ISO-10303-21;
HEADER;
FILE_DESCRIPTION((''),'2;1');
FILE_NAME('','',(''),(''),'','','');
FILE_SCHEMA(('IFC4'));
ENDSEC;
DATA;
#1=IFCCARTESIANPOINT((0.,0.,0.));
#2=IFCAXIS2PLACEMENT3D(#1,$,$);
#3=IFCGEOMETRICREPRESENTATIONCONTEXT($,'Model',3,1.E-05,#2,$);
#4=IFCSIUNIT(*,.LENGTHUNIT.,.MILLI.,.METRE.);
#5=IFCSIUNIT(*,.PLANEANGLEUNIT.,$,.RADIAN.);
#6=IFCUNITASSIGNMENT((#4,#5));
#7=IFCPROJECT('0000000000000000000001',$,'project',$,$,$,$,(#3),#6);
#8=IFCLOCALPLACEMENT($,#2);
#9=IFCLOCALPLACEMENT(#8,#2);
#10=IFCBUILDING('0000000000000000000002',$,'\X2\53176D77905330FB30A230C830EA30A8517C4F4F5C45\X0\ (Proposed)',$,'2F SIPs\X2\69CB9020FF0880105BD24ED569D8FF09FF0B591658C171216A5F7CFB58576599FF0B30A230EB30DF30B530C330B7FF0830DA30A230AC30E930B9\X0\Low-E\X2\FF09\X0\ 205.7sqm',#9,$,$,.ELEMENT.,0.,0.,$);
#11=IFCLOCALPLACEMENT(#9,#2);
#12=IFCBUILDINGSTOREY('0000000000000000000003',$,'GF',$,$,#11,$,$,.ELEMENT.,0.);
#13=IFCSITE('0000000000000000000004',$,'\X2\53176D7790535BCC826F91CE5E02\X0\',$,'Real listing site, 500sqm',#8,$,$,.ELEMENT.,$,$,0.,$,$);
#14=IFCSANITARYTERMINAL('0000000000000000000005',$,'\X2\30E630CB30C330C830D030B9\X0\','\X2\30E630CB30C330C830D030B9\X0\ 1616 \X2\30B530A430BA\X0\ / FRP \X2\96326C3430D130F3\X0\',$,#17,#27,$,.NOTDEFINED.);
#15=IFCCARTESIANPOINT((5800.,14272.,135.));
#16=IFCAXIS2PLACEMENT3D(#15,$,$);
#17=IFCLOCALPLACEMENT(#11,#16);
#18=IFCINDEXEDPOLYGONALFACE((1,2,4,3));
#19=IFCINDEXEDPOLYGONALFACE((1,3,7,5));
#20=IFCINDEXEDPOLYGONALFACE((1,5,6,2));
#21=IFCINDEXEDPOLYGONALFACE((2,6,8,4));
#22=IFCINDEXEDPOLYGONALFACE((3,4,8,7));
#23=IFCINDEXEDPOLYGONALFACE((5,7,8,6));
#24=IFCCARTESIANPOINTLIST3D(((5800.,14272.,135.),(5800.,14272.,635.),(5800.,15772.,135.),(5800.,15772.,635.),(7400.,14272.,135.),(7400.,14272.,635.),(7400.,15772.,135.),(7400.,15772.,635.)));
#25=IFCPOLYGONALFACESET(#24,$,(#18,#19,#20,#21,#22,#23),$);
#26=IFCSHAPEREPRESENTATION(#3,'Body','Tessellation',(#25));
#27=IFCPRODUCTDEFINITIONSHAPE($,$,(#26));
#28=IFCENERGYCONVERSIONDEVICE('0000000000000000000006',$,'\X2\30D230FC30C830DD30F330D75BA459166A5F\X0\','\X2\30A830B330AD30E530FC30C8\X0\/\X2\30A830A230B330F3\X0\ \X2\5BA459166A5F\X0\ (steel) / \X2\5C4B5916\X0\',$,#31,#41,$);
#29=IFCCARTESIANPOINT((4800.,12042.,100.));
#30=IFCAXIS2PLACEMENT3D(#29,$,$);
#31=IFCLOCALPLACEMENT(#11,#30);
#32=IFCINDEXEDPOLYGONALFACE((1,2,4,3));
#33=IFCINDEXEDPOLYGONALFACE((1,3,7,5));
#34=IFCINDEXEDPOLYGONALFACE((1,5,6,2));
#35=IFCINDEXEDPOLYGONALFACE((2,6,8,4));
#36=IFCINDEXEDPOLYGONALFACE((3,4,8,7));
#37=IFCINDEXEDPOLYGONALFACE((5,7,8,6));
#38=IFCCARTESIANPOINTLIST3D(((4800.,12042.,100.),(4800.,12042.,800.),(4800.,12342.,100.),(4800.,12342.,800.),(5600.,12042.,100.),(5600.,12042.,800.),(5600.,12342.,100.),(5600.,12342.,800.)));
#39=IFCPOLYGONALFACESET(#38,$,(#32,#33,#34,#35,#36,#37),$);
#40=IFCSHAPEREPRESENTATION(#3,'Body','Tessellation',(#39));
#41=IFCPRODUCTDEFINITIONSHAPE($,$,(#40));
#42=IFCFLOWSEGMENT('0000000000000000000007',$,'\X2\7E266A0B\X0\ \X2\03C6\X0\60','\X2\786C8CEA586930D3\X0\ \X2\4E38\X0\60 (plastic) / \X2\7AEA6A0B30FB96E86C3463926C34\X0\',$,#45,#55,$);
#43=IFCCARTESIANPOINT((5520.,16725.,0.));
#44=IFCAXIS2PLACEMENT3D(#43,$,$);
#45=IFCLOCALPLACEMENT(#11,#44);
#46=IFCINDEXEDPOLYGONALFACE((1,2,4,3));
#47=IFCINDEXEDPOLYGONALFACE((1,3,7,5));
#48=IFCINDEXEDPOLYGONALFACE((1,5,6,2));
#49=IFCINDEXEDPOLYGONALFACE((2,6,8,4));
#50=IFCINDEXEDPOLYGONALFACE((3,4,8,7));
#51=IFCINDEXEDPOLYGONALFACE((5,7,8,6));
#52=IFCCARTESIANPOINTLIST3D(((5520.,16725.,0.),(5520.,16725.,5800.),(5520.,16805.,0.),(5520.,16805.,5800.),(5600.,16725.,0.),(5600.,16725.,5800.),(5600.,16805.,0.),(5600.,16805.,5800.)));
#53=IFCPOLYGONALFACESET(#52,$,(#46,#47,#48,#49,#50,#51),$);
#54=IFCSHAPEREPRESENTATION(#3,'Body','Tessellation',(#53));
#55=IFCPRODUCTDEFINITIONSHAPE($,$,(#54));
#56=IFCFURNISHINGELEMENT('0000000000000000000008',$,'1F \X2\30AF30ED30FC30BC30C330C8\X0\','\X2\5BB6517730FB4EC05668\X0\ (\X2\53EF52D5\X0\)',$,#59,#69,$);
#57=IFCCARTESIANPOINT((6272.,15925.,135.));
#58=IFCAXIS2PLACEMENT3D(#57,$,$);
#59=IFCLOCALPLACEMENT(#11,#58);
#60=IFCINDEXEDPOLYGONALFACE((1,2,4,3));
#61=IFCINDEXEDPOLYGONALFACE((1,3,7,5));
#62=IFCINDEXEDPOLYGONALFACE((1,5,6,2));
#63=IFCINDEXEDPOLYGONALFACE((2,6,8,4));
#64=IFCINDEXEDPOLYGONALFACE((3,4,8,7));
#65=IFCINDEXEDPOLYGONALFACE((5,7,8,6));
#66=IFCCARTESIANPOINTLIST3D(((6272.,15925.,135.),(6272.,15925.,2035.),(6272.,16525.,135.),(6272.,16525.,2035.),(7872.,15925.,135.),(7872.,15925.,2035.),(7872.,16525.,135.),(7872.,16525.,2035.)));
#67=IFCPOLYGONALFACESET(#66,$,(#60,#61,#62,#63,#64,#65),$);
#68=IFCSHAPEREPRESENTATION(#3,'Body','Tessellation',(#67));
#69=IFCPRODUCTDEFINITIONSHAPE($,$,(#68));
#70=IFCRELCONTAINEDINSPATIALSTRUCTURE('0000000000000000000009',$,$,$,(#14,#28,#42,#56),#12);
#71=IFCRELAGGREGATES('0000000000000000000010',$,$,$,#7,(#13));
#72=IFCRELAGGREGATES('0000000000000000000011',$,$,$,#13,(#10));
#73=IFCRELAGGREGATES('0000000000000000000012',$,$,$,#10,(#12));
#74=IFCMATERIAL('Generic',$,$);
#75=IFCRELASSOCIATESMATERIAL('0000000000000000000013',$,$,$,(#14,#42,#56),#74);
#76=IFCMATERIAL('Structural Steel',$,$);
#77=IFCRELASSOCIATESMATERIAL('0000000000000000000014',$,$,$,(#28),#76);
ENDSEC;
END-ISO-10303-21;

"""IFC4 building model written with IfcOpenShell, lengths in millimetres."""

from ifc_helpers import new_model, si_unit, frame, frame_2d, origin, place, context, project, spatial, rectangle, extrude, material, element, save


model = new_model("IFC4")

# Units and contexts
model_context = context("Model", 3, precision=1e-05, world=origin())
ifc_project = project(units=[si_unit("LENGTHUNIT", "METRE", prefix="MILLI"), si_unit("PLANEANGLEUNIT", "RADIAN")], contexts=[model_context])

# Site, building, storey
site_placement = place(None, origin())
site = spatial("IfcSite", under=ifc_project, at=site_placement, Name="北海道富良野市", ObjectType="Real listing site, 500sqm", CompositionType="ELEMENT", RefElevation=0.0)
building_placement = place(site_placement, origin())
building = spatial("IfcBuilding", under=site, at=building_placement, Name="北海道・アトリエ兼住居 (Proposed)", ObjectType="2F SIPs構造（耐寒仕様）＋外壁無機系塗料＋アルミサッシ（ペアガラスLow-E） 205.7sqm", CompositionType="ELEMENT", ElevationOfRefHeight=0.0, ElevationOfTerrain=0.0)
storey_placement = place(building_placement, origin())
storey = spatial("IfcBuildingStorey", under=building, at=storey_placement, Name="GF", CompositionType="ELEMENT", Elevation=0.0)

# Shared definitions
ifc_material_1 = material(Name="Generic")

# Sanitary terminal
sanitary_terminal_placement = place(storey_placement, frame((5800.0, 14272.0, 135.0)))
element("IfcSanitaryTerminal", 1, at=sanitary_terminal_placement, inside=storey, material=ifc_material_1, Name="ユニットバス", Description="ユニットバス 1616 サイズ / FRP 防水パン", PredefinedType="NOTDEFINED", context=model_context, shape_type="SweptSolid", body=[
    extrude(rectangle(XDim=1600.0, YDim=1500.0, at=frame_2d((800.0, 750.0))), frame((5800.0, 14272.0, 135.0)), (0.0, 0.0, 1.0), 500.0),
])

# Energy conversion device
ifc_material_2 = material(Name="Structural Steel")
energy_conversion_device_placement = place(storey_placement, frame((4800.0, 12042.0, 100.0)))
element("IfcEnergyConversionDevice", 2, at=energy_conversion_device_placement, inside=storey, material=ifc_material_2, Name="ヒートポンプ室外機", Description="エコキュート/エアコン 室外機 (steel) / 屋外", context=model_context, shape_type="SweptSolid", body=[
    extrude(rectangle(XDim=800.0, YDim=300.0, at=frame_2d((400.0, 150.0))), frame((4800.0, 12042.0, 100.0)), (0.0, 0.0, 1.0), 700.0),
])

# Flow segment
flow_segment_placement = place(storey_placement, frame((5520.0, 16725.0, 0.0)))
element("IfcFlowSegment", 3, at=flow_segment_placement, inside=storey, material=ifc_material_1, Name="縦樋 φ60", Description="硬質塩ビ 丸60 (plastic) / 竪樋・雨水排水", context=model_context, shape_type="SweptSolid", body=[
    extrude(rectangle(XDim=80.0, YDim=80.0, at=frame_2d((40.0, 40.0))), frame((5520.0, 16725.0, 0.0)), (0.0, 0.0, 1.0), 5800.0),
])

# Furnishing element
furnishing_placement = place(storey_placement, frame((6272.0, 15925.0, 135.0)))
element("IfcFurnishingElement", 4, at=furnishing_placement, inside=storey, material=ifc_material_1, Name="1F クローゼット", Description="家具・什器 (可動)", context=model_context, shape_type="SweptSolid", body=[
    extrude(rectangle(XDim=1600.0, YDim=600.0, at=frame_2d((800.0, 300.0))), frame((6272.0, 15925.0, 135.0)), (0.0, 0.0, 1.0), 1900.0),
])

save(model, "model.ifc")
